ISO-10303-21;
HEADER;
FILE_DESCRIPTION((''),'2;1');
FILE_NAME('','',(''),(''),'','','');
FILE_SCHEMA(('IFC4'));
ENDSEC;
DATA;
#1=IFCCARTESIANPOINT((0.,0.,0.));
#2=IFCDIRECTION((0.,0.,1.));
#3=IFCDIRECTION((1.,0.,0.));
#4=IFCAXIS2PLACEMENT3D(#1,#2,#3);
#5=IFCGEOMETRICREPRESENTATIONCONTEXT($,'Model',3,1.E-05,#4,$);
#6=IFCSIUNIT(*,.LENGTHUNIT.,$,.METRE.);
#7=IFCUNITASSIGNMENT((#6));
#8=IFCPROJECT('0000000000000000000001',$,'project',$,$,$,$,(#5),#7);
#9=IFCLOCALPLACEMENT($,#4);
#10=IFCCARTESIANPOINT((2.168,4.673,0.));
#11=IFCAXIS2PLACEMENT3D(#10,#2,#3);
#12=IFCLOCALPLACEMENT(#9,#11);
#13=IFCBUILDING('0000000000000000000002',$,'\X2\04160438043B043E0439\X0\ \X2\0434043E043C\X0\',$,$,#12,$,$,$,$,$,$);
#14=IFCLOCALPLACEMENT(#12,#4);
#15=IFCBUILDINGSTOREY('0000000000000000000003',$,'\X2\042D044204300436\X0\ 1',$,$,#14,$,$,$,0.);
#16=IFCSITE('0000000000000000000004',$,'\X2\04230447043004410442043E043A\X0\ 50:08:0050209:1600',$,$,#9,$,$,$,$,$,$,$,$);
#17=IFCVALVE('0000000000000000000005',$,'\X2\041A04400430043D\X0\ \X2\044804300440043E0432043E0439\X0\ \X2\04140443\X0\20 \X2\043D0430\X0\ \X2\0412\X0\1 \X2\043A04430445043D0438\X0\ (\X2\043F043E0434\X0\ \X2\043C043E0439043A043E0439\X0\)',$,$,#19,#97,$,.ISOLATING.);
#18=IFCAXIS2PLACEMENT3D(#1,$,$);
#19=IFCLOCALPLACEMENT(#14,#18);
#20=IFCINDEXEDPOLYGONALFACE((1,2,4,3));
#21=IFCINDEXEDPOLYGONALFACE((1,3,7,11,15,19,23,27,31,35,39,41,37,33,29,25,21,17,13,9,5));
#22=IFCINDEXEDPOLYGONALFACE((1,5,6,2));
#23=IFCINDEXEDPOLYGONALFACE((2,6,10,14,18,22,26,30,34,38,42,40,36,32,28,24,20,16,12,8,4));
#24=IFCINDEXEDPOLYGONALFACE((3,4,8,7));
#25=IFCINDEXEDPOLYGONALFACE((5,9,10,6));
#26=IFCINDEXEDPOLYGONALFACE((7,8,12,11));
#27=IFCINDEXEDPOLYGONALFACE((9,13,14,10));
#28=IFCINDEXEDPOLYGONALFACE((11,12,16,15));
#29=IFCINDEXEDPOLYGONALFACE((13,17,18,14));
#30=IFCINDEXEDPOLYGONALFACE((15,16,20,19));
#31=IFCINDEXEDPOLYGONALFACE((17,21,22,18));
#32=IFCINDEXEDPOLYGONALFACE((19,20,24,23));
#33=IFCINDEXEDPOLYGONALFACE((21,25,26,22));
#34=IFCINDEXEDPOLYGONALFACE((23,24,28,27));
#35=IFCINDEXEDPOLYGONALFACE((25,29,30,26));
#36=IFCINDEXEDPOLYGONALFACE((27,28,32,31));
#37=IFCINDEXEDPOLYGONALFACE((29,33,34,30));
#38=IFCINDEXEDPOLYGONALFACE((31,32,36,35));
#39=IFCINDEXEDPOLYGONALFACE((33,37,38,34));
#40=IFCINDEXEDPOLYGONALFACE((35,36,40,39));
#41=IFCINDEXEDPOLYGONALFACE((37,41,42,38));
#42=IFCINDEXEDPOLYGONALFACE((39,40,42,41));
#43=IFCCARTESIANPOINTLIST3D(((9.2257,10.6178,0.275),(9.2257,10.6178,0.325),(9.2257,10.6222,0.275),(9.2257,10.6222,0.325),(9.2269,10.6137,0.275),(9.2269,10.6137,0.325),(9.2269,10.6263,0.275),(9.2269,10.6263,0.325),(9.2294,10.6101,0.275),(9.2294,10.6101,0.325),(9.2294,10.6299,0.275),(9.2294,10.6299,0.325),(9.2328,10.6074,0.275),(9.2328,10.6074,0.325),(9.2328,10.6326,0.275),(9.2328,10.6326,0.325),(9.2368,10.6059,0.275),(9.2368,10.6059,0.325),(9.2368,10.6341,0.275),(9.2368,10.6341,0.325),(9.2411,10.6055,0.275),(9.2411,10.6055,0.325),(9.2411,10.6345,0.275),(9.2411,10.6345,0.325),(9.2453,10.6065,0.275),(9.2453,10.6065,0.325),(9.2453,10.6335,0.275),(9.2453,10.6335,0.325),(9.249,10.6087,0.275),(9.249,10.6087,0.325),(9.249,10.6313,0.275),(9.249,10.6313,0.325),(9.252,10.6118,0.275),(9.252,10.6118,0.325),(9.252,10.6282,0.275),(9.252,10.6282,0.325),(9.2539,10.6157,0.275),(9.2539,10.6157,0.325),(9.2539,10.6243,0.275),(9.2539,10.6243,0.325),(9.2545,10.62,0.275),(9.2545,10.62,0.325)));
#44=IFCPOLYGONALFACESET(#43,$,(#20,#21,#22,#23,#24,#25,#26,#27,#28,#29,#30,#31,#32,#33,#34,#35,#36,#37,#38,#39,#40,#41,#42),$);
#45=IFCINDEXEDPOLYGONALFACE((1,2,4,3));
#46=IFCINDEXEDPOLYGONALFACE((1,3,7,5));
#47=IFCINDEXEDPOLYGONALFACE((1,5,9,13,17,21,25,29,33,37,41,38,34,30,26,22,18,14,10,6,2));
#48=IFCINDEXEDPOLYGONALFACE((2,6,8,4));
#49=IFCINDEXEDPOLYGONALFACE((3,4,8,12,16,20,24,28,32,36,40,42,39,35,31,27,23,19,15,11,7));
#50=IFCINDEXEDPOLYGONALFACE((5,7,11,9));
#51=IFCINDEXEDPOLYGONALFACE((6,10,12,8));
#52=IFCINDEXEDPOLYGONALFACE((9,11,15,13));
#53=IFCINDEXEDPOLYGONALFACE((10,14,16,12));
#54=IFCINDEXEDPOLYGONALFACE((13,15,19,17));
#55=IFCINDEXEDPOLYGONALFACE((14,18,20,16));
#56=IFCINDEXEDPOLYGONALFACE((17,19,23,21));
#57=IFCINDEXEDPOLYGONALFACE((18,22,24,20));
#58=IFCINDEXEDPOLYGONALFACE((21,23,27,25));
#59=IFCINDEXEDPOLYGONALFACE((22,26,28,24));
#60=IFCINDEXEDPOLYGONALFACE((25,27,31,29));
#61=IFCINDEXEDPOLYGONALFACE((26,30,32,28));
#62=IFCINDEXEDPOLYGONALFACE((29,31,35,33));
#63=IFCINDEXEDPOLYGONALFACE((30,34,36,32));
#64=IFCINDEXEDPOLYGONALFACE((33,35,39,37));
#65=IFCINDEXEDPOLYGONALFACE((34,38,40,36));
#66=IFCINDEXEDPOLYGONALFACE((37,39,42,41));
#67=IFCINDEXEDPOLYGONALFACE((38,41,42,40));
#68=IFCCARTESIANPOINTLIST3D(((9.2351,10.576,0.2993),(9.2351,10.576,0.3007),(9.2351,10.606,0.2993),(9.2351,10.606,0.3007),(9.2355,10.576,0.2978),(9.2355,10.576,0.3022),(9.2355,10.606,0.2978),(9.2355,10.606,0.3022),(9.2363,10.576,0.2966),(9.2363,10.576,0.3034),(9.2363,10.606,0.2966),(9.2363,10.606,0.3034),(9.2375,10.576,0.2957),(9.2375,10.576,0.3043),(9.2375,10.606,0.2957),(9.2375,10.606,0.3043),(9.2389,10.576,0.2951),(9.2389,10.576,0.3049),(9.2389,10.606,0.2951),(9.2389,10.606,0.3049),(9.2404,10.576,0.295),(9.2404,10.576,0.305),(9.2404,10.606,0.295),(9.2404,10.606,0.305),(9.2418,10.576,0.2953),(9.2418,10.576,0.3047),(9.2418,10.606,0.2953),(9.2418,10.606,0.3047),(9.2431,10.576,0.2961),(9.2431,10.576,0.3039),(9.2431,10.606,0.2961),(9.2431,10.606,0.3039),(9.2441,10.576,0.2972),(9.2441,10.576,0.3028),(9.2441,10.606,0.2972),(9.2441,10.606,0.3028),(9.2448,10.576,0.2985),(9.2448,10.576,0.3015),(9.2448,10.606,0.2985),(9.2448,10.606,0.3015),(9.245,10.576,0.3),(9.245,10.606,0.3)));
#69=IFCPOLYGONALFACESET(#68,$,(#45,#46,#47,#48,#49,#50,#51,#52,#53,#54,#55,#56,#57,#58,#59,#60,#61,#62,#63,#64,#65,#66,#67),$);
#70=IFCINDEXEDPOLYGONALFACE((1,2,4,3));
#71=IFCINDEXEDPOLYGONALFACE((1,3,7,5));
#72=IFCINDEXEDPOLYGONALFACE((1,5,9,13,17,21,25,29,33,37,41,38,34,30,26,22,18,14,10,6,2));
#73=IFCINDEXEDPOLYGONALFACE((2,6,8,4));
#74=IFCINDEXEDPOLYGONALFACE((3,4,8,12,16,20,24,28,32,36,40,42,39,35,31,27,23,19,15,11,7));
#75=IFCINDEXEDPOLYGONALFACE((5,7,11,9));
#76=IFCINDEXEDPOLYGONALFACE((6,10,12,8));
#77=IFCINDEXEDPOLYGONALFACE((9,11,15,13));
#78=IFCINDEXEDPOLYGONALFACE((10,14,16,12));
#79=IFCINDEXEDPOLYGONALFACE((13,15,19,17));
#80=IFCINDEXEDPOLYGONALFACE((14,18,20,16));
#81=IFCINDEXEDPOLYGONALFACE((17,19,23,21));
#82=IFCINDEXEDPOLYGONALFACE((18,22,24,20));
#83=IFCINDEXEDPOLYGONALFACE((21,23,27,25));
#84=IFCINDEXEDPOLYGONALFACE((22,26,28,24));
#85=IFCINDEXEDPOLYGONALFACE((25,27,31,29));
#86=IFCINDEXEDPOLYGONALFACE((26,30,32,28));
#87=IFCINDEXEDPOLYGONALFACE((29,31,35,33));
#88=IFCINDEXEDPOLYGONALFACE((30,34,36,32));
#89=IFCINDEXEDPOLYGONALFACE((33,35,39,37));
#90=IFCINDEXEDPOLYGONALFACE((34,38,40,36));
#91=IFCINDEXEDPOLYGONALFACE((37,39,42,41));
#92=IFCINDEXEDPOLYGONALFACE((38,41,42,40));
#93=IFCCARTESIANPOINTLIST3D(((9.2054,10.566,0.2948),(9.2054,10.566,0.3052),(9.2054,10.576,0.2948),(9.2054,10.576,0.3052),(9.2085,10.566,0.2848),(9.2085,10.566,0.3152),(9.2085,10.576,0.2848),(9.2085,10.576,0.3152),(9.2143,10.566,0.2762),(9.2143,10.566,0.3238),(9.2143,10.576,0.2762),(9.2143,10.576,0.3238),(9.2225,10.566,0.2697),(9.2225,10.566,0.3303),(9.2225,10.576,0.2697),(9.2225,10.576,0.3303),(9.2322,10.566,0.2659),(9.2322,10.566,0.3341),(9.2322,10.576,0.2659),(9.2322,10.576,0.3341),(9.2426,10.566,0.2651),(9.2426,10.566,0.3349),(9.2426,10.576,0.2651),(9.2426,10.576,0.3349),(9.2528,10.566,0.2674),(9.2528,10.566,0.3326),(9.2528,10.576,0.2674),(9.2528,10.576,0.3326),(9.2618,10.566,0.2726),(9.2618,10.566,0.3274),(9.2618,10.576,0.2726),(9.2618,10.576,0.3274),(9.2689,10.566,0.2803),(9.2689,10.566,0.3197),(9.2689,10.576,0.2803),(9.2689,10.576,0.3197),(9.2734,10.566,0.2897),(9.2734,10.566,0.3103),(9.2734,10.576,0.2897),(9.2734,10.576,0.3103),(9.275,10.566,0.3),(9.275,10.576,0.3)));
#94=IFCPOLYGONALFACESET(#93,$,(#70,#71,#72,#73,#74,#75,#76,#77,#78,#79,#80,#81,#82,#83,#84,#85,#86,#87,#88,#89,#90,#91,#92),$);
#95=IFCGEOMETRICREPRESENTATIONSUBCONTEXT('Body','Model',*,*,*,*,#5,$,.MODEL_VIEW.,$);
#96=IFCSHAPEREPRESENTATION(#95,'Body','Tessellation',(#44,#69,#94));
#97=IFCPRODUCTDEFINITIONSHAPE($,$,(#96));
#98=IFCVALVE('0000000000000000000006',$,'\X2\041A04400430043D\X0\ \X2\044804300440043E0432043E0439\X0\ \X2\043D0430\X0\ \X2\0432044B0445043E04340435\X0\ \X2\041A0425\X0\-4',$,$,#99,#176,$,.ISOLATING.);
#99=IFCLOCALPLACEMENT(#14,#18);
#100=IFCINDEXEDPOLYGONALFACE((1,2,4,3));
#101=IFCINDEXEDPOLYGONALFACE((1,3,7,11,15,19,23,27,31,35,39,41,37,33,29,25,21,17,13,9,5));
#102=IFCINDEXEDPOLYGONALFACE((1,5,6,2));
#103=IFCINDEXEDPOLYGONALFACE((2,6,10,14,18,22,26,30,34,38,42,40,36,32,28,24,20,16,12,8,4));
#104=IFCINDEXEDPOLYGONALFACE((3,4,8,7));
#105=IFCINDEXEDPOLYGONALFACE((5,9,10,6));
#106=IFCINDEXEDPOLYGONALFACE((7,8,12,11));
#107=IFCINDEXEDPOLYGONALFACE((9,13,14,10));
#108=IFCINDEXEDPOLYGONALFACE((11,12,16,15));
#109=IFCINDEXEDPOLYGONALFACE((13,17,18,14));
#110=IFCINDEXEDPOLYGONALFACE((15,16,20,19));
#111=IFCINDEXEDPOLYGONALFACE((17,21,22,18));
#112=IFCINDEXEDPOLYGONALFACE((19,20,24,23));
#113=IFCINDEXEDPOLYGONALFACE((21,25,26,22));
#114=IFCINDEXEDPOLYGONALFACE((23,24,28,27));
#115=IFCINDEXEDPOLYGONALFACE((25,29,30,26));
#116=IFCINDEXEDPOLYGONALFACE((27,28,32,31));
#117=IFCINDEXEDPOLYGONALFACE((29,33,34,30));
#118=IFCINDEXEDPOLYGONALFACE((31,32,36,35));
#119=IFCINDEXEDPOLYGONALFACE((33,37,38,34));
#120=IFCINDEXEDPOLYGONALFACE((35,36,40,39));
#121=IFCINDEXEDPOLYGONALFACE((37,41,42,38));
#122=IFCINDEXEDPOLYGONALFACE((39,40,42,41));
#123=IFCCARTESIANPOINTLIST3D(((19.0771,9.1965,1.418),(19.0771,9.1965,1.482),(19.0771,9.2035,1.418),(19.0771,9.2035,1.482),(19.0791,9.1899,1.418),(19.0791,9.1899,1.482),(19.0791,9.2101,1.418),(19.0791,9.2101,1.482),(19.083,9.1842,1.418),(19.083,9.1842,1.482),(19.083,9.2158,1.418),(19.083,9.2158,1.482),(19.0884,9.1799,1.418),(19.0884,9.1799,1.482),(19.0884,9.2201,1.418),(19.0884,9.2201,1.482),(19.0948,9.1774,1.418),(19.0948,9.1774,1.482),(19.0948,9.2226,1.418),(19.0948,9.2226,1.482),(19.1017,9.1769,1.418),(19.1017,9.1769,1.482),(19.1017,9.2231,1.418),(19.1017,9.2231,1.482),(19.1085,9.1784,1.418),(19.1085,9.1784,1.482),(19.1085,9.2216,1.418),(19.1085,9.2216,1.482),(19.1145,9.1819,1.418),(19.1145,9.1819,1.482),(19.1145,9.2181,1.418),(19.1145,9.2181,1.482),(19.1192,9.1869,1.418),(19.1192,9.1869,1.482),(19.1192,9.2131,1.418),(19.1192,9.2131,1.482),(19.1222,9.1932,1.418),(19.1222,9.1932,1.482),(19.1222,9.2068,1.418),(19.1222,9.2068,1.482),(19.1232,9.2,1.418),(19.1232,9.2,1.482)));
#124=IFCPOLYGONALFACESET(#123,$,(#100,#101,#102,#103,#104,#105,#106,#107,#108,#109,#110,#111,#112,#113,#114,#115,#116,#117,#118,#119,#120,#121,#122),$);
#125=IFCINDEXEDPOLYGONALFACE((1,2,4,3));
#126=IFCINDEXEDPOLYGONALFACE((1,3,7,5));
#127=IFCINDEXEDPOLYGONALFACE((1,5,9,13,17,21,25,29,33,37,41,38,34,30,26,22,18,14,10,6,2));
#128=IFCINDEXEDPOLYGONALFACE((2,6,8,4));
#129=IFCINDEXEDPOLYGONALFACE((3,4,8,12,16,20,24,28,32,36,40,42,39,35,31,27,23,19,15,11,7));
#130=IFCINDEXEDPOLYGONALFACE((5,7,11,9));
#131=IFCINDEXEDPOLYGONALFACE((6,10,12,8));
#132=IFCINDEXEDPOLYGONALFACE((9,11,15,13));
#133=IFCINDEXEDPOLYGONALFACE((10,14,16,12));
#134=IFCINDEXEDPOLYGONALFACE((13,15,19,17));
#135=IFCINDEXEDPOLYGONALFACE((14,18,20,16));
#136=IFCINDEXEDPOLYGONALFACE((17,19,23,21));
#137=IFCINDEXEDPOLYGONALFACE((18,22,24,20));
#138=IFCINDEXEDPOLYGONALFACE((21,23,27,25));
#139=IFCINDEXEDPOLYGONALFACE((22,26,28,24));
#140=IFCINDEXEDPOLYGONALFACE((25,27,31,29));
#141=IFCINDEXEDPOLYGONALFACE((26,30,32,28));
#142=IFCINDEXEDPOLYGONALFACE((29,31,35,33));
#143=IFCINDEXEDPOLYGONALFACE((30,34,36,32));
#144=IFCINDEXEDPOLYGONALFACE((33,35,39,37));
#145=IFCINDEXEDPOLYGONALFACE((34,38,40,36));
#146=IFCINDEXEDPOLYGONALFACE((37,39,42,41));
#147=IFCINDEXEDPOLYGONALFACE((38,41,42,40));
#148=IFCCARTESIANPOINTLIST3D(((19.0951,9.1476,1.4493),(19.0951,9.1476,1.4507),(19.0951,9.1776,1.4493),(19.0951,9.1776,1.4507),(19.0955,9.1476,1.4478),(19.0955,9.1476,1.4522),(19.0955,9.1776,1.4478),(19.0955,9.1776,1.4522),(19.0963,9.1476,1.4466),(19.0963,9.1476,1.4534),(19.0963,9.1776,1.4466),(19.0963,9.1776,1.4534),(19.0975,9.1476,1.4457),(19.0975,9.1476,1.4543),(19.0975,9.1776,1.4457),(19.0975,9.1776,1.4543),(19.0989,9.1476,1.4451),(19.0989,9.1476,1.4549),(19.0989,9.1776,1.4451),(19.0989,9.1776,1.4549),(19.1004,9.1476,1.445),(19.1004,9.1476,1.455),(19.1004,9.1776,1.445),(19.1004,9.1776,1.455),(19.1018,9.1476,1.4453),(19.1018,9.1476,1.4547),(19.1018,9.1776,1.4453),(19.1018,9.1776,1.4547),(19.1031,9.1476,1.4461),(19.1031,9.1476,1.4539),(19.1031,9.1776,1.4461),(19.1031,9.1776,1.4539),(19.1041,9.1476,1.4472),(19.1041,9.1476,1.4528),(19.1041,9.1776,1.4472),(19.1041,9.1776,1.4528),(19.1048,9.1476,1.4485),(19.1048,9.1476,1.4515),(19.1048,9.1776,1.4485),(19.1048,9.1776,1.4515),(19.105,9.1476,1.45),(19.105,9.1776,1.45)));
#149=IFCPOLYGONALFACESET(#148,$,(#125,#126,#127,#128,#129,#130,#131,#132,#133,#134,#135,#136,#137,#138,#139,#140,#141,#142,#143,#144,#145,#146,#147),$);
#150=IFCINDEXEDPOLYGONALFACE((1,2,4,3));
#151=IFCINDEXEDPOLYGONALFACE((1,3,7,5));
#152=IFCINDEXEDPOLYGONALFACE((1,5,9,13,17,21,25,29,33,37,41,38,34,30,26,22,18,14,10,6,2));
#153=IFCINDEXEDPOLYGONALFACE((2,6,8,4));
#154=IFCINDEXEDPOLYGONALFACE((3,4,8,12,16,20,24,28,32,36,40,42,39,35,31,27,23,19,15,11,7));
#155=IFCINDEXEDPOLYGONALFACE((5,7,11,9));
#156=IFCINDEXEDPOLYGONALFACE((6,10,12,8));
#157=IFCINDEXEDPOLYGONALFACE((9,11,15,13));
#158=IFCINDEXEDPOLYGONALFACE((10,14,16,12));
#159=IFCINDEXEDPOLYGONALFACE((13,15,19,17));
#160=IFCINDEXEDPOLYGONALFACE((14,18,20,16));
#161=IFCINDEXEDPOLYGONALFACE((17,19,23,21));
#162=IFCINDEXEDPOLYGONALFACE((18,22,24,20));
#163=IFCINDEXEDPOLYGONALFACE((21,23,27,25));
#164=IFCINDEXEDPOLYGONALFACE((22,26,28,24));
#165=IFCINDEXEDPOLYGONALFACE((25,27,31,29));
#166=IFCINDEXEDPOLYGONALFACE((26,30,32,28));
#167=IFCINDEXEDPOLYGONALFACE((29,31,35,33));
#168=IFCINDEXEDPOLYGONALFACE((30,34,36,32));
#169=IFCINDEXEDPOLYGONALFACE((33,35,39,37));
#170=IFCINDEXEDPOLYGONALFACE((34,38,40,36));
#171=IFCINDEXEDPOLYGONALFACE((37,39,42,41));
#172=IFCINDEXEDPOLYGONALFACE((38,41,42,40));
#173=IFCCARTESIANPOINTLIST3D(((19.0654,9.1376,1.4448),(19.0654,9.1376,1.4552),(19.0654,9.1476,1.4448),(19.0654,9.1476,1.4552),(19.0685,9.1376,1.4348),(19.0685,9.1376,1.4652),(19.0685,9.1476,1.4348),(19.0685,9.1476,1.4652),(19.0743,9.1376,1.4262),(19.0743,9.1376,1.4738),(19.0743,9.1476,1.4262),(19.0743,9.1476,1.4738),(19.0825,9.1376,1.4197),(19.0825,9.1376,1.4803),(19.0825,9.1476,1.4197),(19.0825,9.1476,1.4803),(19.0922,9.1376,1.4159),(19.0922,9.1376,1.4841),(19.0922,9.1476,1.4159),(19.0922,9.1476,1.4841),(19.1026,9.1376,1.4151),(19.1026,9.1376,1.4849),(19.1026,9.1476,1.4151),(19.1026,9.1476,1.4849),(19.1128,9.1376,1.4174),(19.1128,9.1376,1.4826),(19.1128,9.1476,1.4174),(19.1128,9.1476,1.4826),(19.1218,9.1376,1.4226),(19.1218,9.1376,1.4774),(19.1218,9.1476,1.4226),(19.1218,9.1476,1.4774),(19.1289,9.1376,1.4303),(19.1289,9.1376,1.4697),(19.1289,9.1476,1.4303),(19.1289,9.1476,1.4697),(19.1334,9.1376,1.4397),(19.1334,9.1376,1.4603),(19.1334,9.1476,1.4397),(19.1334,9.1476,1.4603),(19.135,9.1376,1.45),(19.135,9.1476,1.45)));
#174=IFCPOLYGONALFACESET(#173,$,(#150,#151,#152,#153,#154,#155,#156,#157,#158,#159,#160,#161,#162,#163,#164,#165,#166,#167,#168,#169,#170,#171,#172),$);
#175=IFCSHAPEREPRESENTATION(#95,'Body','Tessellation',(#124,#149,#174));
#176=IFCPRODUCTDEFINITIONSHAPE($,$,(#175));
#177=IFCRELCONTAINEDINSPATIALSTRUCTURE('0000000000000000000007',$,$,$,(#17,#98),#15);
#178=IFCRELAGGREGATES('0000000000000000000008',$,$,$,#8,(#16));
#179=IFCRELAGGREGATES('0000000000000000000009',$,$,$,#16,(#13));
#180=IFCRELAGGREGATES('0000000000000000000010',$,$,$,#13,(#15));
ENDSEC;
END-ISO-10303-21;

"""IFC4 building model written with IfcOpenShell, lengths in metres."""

from ifc_helpers import new_model, si_unit, frame, origin_with_axes, origin_2d, place, context, subcontext, project, spatial, circle, extrude, element, save


model = new_model("IFC4")

# Units and contexts
model_context = context("Model", 3, precision=1e-05, world=origin_with_axes())
body_context = subcontext(model_context, "Body", "Model", "MODEL_VIEW")
ifc_project = project(units=[si_unit("LENGTHUNIT", "METRE")], contexts=[model_context])

# Site, building, storey
site_placement = place(None, origin_with_axes())
site = spatial("IfcSite", under=ifc_project, at=site_placement, Name="Участок 50:08:0050209:1600")
building_placement = place(site_placement, frame((2.168, 4.673, 0.0), z_axis=(0.0, 0.0, 1.0), x_axis=(1.0, 0.0, 0.0)))
building = spatial("IfcBuilding", under=site, at=building_placement, Name="Жилой дом")
storey_placement = place(building_placement, origin_with_axes())
storey = spatial("IfcBuildingStorey", under=building, at=storey_placement, Name="Этаж 1", Elevation=0.0)

# Valves
valve_1_placement = place(storey_placement, origin_with_axes())
element("IfcValve", 1, at=valve_1_placement, inside=storey, Name="Кран шаровой Ду20 на В1 кухни (под мойкой)", PredefinedType="ISOLATING", context=body_context, shape_type="SweptSolid", body=[
    extrude(circle(Radius=0.0145, at=origin_2d()), frame((9.24, 10.62, 0.275), z_axis=(0.0, 0.0, 1.0), x_axis=(1.0, 0.0, 0.0)), (0.0, 0.0, 1.0), 0.05),
    extrude(circle(Radius=0.005, at=origin_2d()), frame((9.24, 10.606, 0.3), z_axis=(0.0, -1.0, 0.0), x_axis=(1.0, 0.0, 0.0)), (0.0, 0.0, 1.0), 0.03),
    extrude(circle(Radius=0.035, at=origin_2d()), frame((9.24, 10.576, 0.3), z_axis=(0.0, -1.0, 0.0), x_axis=(1.0, 0.0, 0.0)), (0.0, 0.0, 1.0), 0.01),
])
valve_2_placement = place(storey_placement, origin_with_axes())
element("IfcValve", 2, at=valve_2_placement, inside=storey, Name="Кран шаровой на выходе КХ-4", PredefinedType="ISOLATING", context=body_context, shape_type="SweptSolid", body=[
    extrude(circle(Radius=0.0232, at=origin_2d()), frame((19.1, 9.2, 1.418), z_axis=(0.0, 0.0, 1.0), x_axis=(1.0, 0.0, 0.0)), (0.0, 0.0, 1.0), 0.064),
    extrude(circle(Radius=0.005, at=origin_2d()), frame((19.1, 9.1776, 1.45), z_axis=(0.0, -1.0, 0.0), x_axis=(1.0, 0.0, 0.0)), (0.0, 0.0, 1.0), 0.03),
    extrude(circle(Radius=0.035, at=origin_2d()), frame((19.1, 9.1476, 1.45), z_axis=(0.0, -1.0, 0.0), x_axis=(1.0, 0.0, 0.0)), (0.0, 0.0, 1.0), 0.01),
])

save(model, "model.ifc")
